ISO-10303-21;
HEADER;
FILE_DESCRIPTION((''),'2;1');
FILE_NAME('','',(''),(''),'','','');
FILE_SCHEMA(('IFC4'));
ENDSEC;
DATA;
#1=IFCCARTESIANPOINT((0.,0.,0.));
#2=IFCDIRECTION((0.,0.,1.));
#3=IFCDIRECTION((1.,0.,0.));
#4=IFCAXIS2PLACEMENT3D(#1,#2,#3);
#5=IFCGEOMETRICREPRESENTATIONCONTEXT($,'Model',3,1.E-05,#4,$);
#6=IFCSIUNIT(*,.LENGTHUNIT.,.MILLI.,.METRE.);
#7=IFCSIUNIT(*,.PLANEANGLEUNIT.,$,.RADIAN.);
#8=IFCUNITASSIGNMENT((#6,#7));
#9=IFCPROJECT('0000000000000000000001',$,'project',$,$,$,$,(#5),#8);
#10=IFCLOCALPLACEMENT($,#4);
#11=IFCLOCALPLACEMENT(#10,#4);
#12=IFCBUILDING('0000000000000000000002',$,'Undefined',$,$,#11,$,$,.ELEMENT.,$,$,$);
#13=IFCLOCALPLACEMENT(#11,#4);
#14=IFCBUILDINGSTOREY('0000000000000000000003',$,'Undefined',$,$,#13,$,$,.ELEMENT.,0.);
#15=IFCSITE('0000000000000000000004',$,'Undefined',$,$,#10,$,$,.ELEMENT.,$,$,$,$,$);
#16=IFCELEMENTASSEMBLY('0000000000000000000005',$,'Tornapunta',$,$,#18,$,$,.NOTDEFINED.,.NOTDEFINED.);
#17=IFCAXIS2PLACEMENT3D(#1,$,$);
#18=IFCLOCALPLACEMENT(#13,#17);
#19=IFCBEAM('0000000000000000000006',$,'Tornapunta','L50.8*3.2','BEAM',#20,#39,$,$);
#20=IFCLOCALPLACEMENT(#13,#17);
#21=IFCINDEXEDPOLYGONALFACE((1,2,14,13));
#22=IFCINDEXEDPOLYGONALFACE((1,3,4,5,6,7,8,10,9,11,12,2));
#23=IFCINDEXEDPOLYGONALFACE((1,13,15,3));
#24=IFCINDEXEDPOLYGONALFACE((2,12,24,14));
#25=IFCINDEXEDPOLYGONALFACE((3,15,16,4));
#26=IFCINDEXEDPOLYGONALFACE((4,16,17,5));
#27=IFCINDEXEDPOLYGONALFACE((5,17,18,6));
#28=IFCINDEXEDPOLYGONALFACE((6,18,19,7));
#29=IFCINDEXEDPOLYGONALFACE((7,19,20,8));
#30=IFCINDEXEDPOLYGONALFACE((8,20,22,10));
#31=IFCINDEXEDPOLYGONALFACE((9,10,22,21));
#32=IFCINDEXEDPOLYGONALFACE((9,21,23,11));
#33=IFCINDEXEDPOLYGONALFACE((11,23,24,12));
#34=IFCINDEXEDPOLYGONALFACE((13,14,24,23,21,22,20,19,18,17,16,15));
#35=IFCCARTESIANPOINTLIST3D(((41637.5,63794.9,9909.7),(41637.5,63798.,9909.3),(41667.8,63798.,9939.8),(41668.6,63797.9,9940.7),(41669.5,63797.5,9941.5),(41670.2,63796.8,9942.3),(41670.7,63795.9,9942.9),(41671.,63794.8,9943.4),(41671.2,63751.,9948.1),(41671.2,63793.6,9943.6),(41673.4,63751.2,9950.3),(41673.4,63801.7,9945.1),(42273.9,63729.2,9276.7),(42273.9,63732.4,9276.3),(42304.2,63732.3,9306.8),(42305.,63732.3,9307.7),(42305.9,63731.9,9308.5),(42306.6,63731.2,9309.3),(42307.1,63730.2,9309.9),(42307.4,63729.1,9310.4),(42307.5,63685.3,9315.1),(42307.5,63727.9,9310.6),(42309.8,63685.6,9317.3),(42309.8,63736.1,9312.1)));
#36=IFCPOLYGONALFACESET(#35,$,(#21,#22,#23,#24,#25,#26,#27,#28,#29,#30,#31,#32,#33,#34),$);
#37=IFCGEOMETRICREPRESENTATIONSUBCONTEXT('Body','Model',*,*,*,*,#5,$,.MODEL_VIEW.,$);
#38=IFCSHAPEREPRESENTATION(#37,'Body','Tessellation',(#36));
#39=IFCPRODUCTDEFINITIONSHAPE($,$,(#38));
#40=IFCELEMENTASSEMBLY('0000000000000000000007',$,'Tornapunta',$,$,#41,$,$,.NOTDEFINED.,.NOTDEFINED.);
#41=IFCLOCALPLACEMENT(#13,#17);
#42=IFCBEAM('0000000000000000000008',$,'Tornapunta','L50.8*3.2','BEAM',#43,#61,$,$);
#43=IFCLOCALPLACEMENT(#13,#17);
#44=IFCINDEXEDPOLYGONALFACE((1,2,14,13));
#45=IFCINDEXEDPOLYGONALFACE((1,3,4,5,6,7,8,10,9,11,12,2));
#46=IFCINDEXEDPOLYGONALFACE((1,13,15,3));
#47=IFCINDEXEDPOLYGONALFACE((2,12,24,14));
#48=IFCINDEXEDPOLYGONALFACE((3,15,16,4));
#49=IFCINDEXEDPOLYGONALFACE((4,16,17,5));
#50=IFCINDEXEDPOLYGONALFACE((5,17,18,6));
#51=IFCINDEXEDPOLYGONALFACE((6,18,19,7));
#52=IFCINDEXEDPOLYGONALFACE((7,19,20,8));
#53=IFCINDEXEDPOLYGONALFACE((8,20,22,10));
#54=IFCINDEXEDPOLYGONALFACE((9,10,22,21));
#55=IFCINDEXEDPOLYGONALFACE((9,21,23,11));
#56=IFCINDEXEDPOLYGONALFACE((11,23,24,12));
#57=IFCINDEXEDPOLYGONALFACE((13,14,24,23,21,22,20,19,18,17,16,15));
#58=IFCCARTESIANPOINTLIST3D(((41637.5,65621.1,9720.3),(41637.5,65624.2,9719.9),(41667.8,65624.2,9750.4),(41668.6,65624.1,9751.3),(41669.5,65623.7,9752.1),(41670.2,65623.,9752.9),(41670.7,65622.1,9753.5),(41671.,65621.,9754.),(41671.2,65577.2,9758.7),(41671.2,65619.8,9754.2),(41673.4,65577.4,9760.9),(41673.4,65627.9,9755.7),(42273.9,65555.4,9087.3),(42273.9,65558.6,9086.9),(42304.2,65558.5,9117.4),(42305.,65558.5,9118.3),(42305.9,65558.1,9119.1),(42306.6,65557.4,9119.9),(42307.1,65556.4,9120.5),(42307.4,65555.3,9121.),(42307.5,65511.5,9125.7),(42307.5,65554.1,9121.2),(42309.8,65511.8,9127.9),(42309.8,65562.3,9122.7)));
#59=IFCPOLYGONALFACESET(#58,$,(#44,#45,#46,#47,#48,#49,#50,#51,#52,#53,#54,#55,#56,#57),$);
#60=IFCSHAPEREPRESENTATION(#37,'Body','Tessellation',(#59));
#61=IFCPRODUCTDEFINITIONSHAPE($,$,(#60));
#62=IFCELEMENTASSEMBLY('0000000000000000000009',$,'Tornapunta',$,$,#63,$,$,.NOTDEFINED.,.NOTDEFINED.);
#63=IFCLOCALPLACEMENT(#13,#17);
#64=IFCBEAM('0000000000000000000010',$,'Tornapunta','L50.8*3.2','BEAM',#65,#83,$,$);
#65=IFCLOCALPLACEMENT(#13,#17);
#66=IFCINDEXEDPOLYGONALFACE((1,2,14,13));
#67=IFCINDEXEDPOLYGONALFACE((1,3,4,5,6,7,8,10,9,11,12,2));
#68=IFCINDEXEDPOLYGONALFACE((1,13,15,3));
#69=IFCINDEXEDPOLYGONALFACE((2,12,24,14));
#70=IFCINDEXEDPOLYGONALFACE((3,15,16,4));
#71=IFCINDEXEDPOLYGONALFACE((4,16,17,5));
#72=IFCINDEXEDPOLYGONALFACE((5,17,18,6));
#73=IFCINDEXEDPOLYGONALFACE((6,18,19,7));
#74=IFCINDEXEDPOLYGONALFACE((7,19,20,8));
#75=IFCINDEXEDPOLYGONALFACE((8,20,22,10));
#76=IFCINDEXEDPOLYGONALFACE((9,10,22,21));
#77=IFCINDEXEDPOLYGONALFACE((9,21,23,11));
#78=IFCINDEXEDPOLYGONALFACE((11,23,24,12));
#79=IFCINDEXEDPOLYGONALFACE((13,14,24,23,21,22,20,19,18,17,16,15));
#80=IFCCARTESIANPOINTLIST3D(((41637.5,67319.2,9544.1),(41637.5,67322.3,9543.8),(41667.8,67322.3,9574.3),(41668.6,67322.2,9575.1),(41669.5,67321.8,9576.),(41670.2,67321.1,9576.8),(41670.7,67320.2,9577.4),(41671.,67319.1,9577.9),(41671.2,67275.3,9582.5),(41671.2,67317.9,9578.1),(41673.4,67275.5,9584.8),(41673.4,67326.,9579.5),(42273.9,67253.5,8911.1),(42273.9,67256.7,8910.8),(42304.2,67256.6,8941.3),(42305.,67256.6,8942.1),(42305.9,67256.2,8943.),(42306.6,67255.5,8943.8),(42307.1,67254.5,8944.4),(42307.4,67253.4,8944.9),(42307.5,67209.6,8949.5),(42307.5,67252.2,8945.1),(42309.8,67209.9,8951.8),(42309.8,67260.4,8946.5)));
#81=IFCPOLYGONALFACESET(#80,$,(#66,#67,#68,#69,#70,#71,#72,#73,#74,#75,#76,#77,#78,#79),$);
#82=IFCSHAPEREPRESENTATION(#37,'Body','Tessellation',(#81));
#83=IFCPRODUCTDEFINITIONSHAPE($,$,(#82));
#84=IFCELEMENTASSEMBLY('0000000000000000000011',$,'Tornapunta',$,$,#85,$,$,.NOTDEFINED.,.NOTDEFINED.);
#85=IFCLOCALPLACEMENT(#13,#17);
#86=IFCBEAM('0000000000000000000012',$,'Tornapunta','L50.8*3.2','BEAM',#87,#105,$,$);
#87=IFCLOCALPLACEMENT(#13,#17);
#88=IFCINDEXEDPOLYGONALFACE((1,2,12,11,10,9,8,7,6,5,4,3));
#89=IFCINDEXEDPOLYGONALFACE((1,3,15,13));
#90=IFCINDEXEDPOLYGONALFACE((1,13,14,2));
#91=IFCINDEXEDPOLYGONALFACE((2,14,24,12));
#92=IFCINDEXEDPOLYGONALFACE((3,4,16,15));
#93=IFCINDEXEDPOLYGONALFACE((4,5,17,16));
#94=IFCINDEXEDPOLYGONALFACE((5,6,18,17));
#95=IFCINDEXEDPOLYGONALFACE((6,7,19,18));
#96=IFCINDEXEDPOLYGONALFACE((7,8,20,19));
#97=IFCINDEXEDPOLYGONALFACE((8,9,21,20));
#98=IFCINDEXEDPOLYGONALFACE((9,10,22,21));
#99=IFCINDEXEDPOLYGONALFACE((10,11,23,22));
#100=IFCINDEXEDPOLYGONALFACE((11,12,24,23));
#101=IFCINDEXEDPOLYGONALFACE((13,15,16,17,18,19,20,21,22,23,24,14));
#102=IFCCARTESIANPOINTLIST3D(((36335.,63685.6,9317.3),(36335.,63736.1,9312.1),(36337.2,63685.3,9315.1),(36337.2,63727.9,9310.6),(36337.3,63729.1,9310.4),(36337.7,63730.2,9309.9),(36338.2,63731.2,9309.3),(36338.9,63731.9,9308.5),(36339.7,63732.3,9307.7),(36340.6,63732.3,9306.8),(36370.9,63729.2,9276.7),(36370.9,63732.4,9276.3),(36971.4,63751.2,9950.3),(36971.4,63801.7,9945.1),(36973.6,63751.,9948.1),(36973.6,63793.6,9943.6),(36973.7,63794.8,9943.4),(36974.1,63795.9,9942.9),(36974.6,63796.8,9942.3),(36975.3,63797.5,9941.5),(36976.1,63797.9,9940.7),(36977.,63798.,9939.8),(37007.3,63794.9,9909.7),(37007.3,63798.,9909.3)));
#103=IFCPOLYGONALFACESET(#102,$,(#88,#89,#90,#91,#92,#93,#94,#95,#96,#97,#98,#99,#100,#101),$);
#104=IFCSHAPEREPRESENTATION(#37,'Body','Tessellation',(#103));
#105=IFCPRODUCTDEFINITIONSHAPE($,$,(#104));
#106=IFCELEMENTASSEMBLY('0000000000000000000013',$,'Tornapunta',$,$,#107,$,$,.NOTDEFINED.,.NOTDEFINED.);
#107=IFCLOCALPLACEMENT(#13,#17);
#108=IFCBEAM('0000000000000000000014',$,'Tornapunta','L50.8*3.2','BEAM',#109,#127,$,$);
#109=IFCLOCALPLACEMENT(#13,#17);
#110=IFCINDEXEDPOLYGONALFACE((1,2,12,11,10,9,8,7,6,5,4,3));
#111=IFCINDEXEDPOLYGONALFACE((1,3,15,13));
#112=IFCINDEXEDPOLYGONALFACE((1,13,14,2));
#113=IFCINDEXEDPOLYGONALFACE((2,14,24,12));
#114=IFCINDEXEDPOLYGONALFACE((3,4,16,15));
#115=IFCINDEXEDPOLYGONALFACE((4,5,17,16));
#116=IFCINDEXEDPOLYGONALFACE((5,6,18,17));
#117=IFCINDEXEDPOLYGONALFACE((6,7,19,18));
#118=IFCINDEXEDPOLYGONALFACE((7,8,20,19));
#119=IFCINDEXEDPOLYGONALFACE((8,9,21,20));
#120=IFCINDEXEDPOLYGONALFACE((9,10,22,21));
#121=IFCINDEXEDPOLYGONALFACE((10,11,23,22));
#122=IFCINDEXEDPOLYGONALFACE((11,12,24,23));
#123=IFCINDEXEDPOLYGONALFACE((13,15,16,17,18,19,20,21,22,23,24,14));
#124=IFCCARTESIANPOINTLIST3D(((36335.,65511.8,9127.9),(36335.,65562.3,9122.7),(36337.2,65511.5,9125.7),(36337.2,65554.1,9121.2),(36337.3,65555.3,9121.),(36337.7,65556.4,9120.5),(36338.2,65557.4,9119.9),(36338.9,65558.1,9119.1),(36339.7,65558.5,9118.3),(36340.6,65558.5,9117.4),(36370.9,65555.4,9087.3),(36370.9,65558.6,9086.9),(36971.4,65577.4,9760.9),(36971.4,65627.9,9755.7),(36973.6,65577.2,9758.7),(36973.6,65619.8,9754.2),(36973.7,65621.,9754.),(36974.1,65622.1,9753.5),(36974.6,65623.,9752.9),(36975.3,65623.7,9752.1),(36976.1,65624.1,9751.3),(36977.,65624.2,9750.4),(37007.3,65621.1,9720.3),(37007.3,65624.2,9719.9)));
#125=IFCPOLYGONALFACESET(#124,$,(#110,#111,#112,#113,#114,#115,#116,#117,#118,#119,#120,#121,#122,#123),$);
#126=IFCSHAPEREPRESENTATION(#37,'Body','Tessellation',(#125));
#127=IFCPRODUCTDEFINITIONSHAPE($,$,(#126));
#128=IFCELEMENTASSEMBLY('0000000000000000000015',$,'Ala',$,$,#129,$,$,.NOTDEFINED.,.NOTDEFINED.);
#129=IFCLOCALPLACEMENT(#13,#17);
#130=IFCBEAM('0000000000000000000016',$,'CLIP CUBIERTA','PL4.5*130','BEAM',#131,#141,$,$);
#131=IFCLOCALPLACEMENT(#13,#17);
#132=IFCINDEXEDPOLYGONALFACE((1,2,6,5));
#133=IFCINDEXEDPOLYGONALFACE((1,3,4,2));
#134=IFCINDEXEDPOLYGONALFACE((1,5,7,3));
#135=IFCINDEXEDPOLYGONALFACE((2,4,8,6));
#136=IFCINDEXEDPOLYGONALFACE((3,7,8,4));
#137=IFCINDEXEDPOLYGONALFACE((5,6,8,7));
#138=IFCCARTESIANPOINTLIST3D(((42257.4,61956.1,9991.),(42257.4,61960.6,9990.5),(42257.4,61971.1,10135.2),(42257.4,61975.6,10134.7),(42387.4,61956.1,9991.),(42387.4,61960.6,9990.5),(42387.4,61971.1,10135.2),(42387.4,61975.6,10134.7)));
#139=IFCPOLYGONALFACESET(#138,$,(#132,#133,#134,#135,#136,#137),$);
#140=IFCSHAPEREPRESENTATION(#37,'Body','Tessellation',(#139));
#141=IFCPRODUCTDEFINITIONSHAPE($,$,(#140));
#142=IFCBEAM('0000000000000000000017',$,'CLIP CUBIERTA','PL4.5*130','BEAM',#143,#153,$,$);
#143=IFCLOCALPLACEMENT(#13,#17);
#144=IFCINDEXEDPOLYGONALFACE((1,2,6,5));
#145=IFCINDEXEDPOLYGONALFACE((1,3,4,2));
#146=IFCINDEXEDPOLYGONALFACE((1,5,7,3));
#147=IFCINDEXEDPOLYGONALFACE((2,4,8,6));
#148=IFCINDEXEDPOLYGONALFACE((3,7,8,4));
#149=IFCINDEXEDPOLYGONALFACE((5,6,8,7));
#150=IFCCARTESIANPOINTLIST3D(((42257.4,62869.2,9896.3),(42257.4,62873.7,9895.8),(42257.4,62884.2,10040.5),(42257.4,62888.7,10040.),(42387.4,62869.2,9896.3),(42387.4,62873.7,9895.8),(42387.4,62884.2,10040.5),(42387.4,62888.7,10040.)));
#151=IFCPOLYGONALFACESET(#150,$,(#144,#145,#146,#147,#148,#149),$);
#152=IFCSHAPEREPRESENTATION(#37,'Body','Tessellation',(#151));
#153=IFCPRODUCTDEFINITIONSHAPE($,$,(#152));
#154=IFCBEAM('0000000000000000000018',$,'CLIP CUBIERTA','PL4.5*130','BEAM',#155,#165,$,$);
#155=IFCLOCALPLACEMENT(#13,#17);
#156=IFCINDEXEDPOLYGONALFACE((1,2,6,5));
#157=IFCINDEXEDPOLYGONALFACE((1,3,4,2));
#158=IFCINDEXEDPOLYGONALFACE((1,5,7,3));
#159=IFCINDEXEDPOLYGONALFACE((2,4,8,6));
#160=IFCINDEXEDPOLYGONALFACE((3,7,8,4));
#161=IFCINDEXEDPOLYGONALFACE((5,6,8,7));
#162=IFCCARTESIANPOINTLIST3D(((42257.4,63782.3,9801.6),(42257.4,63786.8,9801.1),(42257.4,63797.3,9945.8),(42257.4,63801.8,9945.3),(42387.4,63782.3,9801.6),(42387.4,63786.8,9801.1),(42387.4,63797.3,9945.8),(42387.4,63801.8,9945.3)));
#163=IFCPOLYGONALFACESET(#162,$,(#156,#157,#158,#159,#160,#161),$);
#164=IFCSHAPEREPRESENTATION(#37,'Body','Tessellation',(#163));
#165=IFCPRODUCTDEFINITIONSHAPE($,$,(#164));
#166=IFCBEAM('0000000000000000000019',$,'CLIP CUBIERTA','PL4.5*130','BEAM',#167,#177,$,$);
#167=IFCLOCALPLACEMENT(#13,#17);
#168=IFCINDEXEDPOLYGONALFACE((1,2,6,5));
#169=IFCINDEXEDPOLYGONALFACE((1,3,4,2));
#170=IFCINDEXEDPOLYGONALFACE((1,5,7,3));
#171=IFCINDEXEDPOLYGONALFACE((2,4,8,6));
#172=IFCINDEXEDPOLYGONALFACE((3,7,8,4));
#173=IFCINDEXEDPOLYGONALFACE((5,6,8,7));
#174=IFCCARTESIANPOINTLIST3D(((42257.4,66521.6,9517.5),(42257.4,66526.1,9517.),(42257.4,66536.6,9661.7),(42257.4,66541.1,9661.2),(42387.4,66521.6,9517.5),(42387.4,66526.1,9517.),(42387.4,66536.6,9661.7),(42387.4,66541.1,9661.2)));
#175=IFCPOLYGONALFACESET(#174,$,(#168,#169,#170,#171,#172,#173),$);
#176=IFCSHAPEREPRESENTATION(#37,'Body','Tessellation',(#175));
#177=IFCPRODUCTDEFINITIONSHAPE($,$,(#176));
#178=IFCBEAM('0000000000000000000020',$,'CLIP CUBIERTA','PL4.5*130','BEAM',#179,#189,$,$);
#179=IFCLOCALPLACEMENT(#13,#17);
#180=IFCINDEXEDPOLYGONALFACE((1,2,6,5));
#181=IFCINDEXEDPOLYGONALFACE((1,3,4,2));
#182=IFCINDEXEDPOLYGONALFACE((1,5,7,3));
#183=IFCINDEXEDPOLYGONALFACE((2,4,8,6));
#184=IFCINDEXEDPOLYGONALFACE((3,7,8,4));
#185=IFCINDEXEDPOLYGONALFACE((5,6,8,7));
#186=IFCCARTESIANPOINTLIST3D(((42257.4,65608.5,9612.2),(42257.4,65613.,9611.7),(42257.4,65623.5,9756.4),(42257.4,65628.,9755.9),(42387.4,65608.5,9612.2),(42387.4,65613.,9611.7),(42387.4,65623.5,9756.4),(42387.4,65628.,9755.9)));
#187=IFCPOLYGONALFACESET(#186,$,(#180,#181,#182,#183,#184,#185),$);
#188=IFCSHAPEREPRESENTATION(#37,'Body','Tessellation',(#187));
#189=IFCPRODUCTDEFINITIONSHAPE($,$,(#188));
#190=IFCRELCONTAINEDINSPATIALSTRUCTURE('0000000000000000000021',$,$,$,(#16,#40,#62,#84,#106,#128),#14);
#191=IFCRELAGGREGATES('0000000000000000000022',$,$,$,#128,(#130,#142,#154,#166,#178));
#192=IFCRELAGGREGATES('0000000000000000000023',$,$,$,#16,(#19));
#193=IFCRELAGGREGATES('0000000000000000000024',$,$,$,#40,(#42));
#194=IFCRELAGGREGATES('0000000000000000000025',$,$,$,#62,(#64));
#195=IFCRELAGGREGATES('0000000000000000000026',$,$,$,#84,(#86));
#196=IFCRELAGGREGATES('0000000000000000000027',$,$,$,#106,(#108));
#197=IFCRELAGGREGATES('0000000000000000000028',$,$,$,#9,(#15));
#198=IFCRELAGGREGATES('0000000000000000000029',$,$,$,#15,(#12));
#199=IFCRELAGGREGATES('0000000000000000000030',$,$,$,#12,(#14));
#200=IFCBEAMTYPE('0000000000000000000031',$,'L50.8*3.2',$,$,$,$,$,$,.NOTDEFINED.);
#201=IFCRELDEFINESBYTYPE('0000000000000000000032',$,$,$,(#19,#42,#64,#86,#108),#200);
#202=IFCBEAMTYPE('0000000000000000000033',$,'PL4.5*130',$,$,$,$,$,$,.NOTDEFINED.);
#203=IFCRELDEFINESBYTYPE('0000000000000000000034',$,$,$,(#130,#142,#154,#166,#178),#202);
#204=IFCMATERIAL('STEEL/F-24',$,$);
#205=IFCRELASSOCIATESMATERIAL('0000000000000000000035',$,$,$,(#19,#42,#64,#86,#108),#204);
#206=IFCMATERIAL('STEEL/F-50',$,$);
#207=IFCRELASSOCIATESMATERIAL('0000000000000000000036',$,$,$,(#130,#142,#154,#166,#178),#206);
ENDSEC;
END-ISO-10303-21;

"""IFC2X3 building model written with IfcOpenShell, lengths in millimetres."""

from ifc_helpers import new_model, si_unit, frame, origin_with_axes, origin_2d_with_axis, place, context, subcontext, project, spatial, rectangle, l_section, extrude, material, type_object, element, aggregate, save


model = new_model("IFC2X3")

# Units and contexts
model_context = context("Model", 3, precision=1e-05, world=origin_with_axes())
body_context = subcontext(model_context, "Body", "Model", "MODEL_VIEW")
ifc_project = project(units=[si_unit("LENGTHUNIT", "METRE", prefix="MILLI"), si_unit("PLANEANGLEUNIT", "RADIAN")], contexts=[model_context])

# Site, building, storey
site_placement = place(None, origin_with_axes())
site = spatial("IfcSite", under=ifc_project, at=site_placement, Name="Undefined", CompositionType="ELEMENT")
building_placement = place(site_placement, origin_with_axes())
building = spatial("IfcBuilding", under=site, at=building_placement, Name="Undefined", CompositionType="ELEMENT")
storey_placement = place(building_placement, origin_with_axes())
storey = spatial("IfcBuildingStorey", under=building, at=storey_placement, Name="Undefined", CompositionType="ELEMENT", Elevation=0.0)

# Element assemblies, beams
assembly_1_placement = place(storey_placement, origin_with_axes())
assembly_1 = element("IfcElementAssembly", 1, at=assembly_1_placement, inside=storey, Name="Tornapunta", AssemblyPlace="NOTDEFINED", PredefinedType="NOTDEFINED")
ifc_material_1 = material(Name="STEEL/F-24")
beam_type_1 = type_object("IfcBeamType", Name="L50.8*3.2", PredefinedType="NOTDEFINED")
beam_1_placement = place(assembly_1_placement, frame((42291.9, 63709.0, 9296.8), z_axis=(-0.707107, -0.072947, -0.703334), x_axis=(-0.707107, 0.072947, 0.703334)))
beam_1 = element("IfcBeam", 2, at=beam_1_placement, type_object=beam_type_1, material=ifc_material_1, Name="Tornapunta", Description="L50.8*3.2", ObjectType="BEAM", context=body_context, shape_type="SweptSolid", body=[
    extrude(l_section(Depth=50.8, Width=50.8, Thickness=3.2, FilletRadius=4.8, at=origin_2d_with_axis()), frame((900.0, 0.0, 0.0), z_axis=(-1.0, 0.0, 0.0), x_axis=(0.0, -1.0, 0.0)), (0.0, 0.0, 1.0), 900.0),
])
assembly_2_placement = place(storey_placement, origin_with_axes())
assembly_2 = element("IfcElementAssembly", 3, at=assembly_2_placement, inside=storey, Name="Tornapunta", AssemblyPlace="NOTDEFINED", PredefinedType="NOTDEFINED")
beam_2_placement = place(assembly_2_placement, frame((42291.9, 65535.2, 9107.4), z_axis=(-0.707107, -0.072947, -0.703334), x_axis=(-0.707107, 0.072947, 0.703334)))
beam_2 = element("IfcBeam", 4, at=beam_2_placement, type_object=beam_type_1, material=ifc_material_1, Name="Tornapunta", Description="L50.8*3.2", ObjectType="BEAM", context=body_context, shape_type="SweptSolid", body=[
    extrude(l_section(Depth=50.8, Width=50.8, Thickness=3.2, FilletRadius=4.8, at=origin_2d_with_axis()), frame((900.0, 0.0, 0.0), z_axis=(-1.0, 0.0, 0.0), x_axis=(0.0, -1.0, 0.0)), (0.0, 0.0, 1.0), 900.0),
])
assembly_3_placement = place(storey_placement, origin_with_axes())
assembly_3 = element("IfcElementAssembly", 5, at=assembly_3_placement, inside=storey, Name="Tornapunta", AssemblyPlace="NOTDEFINED", PredefinedType="NOTDEFINED")
beam_3_placement = place(assembly_3_placement, frame((42291.9, 67233.3, 8931.3), z_axis=(-0.707107, -0.072947, -0.703334), x_axis=(-0.707107, 0.072947, 0.703334)))
beam_3 = element("IfcBeam", 6, at=beam_3_placement, type_object=beam_type_1, material=ifc_material_1, Name="Tornapunta", Description="L50.8*3.2", ObjectType="BEAM", context=body_context, shape_type="SweptSolid", body=[
    extrude(l_section(Depth=50.8, Width=50.8, Thickness=3.2, FilletRadius=4.8, at=origin_2d_with_axis()), frame((900.0, 0.0, 0.0), z_axis=(-1.0, 0.0, 0.0), x_axis=(0.0, -1.0, 0.0)), (0.0, 0.0, 1.0), 900.0),
])
assembly_4_placement = place(storey_placement, origin_with_axes())
assembly_4 = element("IfcElementAssembly", 7, at=assembly_4_placement, inside=storey, Name="Tornapunta", AssemblyPlace="NOTDEFINED", PredefinedType="NOTDEFINED")
beam_4_placement = place(assembly_4_placement, frame((36989.3, 63774.6, 9929.8), z_axis=(0.707107, -0.072947, -0.703334), x_axis=(-0.707107, -0.072947, -0.703334)))
beam_4 = element("IfcBeam", 8, at=beam_4_placement, type_object=beam_type_1, material=ifc_material_1, Name="Tornapunta", Description="L50.8*3.2", ObjectType="BEAM", context=body_context, shape_type="SweptSolid", body=[
    extrude(l_section(Depth=50.8, Width=50.8, Thickness=3.2, FilletRadius=4.8, at=origin_2d_with_axis()), frame((900.0, 0.0, 0.0), z_axis=(-1.0, 0.0, 0.0), x_axis=(0.0, -1.0, 0.0)), (0.0, 0.0, 1.0), 900.0),
])
assembly_5_placement = place(storey_placement, origin_with_axes())
assembly_5 = element("IfcElementAssembly", 9, at=assembly_5_placement, inside=storey, Name="Tornapunta", AssemblyPlace="NOTDEFINED", PredefinedType="NOTDEFINED")
beam_5_placement = place(assembly_5_placement, frame((36989.3, 65600.8, 9740.4), z_axis=(0.707107, -0.072947, -0.703334), x_axis=(-0.707107, -0.072947, -0.703334)))
beam_5 = element("IfcBeam", 10, at=beam_5_placement, type_object=beam_type_1, material=ifc_material_1, Name="Tornapunta", Description="L50.8*3.2", ObjectType="BEAM", context=body_context, shape_type="SweptSolid", body=[
    extrude(l_section(Depth=50.8, Width=50.8, Thickness=3.2, FilletRadius=4.8, at=origin_2d_with_axis()), frame((900.0, 0.0, 0.0), z_axis=(-1.0, 0.0, 0.0), x_axis=(0.0, -1.0, 0.0)), (0.0, 0.0, 1.0), 900.0),
])

# Element assembly, beams
assembly_6_placement = place(storey_placement, origin_with_axes())
assembly_6 = element("IfcElementAssembly", 11, at=assembly_6_placement, inside=storey, Name="Ala", AssemblyPlace="NOTDEFINED", PredefinedType="NOTDEFINED")
ifc_material_2 = material(Name="STEEL/F-50")
beam_type_2 = type_object("IfcBeamType", Name="PL4.5*130", PredefinedType="NOTDEFINED")
beam_6_placement = place(assembly_6_placement, frame((42322.4, 61958.4, 9990.7), z_axis=(-1.0, 0.0, 0.0), x_axis=(0.0, 0.103162, 0.994665)))
beam_6 = element("IfcBeam", 12, at=beam_6_placement, type_object=beam_type_2, material=ifc_material_2, Name="CLIP CUBIERTA", Description="PL4.5*130", ObjectType="BEAM", context=body_context, shape_type="SweptSolid", body=[
    extrude(rectangle(XDim=4.5, YDim=130.0, at=origin_2d_with_axis()), frame((145.0, 0.0, 0.0), z_axis=(-1.0, 0.0, 0.0), x_axis=(0.0, -1.0, 0.0)), (0.0, 0.0, 1.0), 145.0),
])
beam_7_placement = place(assembly_6_placement, frame((42322.4, 62871.5, 9896.0), z_axis=(-1.0, 0.0, 0.0), x_axis=(0.0, 0.103162, 0.994665)))
beam_7 = element("IfcBeam", 13, at=beam_7_placement, type_object=beam_type_2, material=ifc_material_2, Name="CLIP CUBIERTA", Description="PL4.5*130", ObjectType="BEAM", context=body_context, shape_type="SweptSolid", body=[
    extrude(rectangle(XDim=4.5, YDim=130.0, at=origin_2d_with_axis()), frame((145.0, 0.0, 0.0), z_axis=(-1.0, 0.0, 0.0), x_axis=(0.0, -1.0, 0.0)), (0.0, 0.0, 1.0), 145.0),
])
beam_8_placement = place(assembly_6_placement, frame((42322.4, 63784.6, 9801.3), z_axis=(-1.0, 0.0, 0.0), x_axis=(0.0, 0.103162, 0.994665)))
beam_8 = element("IfcBeam", 14, at=beam_8_placement, type_object=beam_type_2, material=ifc_material_2, Name="CLIP CUBIERTA", Description="PL4.5*130", ObjectType="BEAM", context=body_context, shape_type="SweptSolid", body=[
    extrude(rectangle(XDim=4.5, YDim=130.0, at=origin_2d_with_axis()), frame((145.0, 0.0, 0.0), z_axis=(-1.0, 0.0, 0.0), x_axis=(0.0, -1.0, 0.0)), (0.0, 0.0, 1.0), 145.0),
])
beam_9_placement = place(assembly_6_placement, frame((42322.4, 66523.9, 9517.2), z_axis=(-1.0, 0.0, 0.0), x_axis=(0.0, 0.103162, 0.994665)))
beam_9 = element("IfcBeam", 15, at=beam_9_placement, type_object=beam_type_2, material=ifc_material_2, Name="CLIP CUBIERTA", Description="PL4.5*130", ObjectType="BEAM", context=body_context, shape_type="SweptSolid", body=[
    extrude(rectangle(XDim=4.5, YDim=130.0, at=origin_2d_with_axis()), frame((145.0, 0.0, 0.0), z_axis=(-1.0, 0.0, 0.0), x_axis=(0.0, -1.0, 0.0)), (0.0, 0.0, 1.0), 145.0),
])
beam_10_placement = place(assembly_6_placement, frame((42322.4, 65610.8, 9611.9), z_axis=(-1.0, 0.0, 0.0), x_axis=(0.0, 0.103162, 0.994665)))
beam_10 = element("IfcBeam", 16, at=beam_10_placement, type_object=beam_type_2, material=ifc_material_2, Name="CLIP CUBIERTA", Description="PL4.5*130", ObjectType="BEAM", context=body_context, shape_type="SweptSolid", body=[
    extrude(rectangle(XDim=4.5, YDim=130.0, at=origin_2d_with_axis()), frame((145.0, 0.0, 0.0), z_axis=(-1.0, 0.0, 0.0), x_axis=(0.0, -1.0, 0.0)), (0.0, 0.0, 1.0), 145.0),
])

aggregate(assembly_6, [beam_6, beam_7, beam_8, beam_9, beam_10])

aggregate(assembly_1, [beam_1])
aggregate(assembly_2, [beam_2])
aggregate(assembly_3, [beam_3])
aggregate(assembly_4, [beam_4])
aggregate(assembly_5, [beam_5])

save(model, "model.ifc")
